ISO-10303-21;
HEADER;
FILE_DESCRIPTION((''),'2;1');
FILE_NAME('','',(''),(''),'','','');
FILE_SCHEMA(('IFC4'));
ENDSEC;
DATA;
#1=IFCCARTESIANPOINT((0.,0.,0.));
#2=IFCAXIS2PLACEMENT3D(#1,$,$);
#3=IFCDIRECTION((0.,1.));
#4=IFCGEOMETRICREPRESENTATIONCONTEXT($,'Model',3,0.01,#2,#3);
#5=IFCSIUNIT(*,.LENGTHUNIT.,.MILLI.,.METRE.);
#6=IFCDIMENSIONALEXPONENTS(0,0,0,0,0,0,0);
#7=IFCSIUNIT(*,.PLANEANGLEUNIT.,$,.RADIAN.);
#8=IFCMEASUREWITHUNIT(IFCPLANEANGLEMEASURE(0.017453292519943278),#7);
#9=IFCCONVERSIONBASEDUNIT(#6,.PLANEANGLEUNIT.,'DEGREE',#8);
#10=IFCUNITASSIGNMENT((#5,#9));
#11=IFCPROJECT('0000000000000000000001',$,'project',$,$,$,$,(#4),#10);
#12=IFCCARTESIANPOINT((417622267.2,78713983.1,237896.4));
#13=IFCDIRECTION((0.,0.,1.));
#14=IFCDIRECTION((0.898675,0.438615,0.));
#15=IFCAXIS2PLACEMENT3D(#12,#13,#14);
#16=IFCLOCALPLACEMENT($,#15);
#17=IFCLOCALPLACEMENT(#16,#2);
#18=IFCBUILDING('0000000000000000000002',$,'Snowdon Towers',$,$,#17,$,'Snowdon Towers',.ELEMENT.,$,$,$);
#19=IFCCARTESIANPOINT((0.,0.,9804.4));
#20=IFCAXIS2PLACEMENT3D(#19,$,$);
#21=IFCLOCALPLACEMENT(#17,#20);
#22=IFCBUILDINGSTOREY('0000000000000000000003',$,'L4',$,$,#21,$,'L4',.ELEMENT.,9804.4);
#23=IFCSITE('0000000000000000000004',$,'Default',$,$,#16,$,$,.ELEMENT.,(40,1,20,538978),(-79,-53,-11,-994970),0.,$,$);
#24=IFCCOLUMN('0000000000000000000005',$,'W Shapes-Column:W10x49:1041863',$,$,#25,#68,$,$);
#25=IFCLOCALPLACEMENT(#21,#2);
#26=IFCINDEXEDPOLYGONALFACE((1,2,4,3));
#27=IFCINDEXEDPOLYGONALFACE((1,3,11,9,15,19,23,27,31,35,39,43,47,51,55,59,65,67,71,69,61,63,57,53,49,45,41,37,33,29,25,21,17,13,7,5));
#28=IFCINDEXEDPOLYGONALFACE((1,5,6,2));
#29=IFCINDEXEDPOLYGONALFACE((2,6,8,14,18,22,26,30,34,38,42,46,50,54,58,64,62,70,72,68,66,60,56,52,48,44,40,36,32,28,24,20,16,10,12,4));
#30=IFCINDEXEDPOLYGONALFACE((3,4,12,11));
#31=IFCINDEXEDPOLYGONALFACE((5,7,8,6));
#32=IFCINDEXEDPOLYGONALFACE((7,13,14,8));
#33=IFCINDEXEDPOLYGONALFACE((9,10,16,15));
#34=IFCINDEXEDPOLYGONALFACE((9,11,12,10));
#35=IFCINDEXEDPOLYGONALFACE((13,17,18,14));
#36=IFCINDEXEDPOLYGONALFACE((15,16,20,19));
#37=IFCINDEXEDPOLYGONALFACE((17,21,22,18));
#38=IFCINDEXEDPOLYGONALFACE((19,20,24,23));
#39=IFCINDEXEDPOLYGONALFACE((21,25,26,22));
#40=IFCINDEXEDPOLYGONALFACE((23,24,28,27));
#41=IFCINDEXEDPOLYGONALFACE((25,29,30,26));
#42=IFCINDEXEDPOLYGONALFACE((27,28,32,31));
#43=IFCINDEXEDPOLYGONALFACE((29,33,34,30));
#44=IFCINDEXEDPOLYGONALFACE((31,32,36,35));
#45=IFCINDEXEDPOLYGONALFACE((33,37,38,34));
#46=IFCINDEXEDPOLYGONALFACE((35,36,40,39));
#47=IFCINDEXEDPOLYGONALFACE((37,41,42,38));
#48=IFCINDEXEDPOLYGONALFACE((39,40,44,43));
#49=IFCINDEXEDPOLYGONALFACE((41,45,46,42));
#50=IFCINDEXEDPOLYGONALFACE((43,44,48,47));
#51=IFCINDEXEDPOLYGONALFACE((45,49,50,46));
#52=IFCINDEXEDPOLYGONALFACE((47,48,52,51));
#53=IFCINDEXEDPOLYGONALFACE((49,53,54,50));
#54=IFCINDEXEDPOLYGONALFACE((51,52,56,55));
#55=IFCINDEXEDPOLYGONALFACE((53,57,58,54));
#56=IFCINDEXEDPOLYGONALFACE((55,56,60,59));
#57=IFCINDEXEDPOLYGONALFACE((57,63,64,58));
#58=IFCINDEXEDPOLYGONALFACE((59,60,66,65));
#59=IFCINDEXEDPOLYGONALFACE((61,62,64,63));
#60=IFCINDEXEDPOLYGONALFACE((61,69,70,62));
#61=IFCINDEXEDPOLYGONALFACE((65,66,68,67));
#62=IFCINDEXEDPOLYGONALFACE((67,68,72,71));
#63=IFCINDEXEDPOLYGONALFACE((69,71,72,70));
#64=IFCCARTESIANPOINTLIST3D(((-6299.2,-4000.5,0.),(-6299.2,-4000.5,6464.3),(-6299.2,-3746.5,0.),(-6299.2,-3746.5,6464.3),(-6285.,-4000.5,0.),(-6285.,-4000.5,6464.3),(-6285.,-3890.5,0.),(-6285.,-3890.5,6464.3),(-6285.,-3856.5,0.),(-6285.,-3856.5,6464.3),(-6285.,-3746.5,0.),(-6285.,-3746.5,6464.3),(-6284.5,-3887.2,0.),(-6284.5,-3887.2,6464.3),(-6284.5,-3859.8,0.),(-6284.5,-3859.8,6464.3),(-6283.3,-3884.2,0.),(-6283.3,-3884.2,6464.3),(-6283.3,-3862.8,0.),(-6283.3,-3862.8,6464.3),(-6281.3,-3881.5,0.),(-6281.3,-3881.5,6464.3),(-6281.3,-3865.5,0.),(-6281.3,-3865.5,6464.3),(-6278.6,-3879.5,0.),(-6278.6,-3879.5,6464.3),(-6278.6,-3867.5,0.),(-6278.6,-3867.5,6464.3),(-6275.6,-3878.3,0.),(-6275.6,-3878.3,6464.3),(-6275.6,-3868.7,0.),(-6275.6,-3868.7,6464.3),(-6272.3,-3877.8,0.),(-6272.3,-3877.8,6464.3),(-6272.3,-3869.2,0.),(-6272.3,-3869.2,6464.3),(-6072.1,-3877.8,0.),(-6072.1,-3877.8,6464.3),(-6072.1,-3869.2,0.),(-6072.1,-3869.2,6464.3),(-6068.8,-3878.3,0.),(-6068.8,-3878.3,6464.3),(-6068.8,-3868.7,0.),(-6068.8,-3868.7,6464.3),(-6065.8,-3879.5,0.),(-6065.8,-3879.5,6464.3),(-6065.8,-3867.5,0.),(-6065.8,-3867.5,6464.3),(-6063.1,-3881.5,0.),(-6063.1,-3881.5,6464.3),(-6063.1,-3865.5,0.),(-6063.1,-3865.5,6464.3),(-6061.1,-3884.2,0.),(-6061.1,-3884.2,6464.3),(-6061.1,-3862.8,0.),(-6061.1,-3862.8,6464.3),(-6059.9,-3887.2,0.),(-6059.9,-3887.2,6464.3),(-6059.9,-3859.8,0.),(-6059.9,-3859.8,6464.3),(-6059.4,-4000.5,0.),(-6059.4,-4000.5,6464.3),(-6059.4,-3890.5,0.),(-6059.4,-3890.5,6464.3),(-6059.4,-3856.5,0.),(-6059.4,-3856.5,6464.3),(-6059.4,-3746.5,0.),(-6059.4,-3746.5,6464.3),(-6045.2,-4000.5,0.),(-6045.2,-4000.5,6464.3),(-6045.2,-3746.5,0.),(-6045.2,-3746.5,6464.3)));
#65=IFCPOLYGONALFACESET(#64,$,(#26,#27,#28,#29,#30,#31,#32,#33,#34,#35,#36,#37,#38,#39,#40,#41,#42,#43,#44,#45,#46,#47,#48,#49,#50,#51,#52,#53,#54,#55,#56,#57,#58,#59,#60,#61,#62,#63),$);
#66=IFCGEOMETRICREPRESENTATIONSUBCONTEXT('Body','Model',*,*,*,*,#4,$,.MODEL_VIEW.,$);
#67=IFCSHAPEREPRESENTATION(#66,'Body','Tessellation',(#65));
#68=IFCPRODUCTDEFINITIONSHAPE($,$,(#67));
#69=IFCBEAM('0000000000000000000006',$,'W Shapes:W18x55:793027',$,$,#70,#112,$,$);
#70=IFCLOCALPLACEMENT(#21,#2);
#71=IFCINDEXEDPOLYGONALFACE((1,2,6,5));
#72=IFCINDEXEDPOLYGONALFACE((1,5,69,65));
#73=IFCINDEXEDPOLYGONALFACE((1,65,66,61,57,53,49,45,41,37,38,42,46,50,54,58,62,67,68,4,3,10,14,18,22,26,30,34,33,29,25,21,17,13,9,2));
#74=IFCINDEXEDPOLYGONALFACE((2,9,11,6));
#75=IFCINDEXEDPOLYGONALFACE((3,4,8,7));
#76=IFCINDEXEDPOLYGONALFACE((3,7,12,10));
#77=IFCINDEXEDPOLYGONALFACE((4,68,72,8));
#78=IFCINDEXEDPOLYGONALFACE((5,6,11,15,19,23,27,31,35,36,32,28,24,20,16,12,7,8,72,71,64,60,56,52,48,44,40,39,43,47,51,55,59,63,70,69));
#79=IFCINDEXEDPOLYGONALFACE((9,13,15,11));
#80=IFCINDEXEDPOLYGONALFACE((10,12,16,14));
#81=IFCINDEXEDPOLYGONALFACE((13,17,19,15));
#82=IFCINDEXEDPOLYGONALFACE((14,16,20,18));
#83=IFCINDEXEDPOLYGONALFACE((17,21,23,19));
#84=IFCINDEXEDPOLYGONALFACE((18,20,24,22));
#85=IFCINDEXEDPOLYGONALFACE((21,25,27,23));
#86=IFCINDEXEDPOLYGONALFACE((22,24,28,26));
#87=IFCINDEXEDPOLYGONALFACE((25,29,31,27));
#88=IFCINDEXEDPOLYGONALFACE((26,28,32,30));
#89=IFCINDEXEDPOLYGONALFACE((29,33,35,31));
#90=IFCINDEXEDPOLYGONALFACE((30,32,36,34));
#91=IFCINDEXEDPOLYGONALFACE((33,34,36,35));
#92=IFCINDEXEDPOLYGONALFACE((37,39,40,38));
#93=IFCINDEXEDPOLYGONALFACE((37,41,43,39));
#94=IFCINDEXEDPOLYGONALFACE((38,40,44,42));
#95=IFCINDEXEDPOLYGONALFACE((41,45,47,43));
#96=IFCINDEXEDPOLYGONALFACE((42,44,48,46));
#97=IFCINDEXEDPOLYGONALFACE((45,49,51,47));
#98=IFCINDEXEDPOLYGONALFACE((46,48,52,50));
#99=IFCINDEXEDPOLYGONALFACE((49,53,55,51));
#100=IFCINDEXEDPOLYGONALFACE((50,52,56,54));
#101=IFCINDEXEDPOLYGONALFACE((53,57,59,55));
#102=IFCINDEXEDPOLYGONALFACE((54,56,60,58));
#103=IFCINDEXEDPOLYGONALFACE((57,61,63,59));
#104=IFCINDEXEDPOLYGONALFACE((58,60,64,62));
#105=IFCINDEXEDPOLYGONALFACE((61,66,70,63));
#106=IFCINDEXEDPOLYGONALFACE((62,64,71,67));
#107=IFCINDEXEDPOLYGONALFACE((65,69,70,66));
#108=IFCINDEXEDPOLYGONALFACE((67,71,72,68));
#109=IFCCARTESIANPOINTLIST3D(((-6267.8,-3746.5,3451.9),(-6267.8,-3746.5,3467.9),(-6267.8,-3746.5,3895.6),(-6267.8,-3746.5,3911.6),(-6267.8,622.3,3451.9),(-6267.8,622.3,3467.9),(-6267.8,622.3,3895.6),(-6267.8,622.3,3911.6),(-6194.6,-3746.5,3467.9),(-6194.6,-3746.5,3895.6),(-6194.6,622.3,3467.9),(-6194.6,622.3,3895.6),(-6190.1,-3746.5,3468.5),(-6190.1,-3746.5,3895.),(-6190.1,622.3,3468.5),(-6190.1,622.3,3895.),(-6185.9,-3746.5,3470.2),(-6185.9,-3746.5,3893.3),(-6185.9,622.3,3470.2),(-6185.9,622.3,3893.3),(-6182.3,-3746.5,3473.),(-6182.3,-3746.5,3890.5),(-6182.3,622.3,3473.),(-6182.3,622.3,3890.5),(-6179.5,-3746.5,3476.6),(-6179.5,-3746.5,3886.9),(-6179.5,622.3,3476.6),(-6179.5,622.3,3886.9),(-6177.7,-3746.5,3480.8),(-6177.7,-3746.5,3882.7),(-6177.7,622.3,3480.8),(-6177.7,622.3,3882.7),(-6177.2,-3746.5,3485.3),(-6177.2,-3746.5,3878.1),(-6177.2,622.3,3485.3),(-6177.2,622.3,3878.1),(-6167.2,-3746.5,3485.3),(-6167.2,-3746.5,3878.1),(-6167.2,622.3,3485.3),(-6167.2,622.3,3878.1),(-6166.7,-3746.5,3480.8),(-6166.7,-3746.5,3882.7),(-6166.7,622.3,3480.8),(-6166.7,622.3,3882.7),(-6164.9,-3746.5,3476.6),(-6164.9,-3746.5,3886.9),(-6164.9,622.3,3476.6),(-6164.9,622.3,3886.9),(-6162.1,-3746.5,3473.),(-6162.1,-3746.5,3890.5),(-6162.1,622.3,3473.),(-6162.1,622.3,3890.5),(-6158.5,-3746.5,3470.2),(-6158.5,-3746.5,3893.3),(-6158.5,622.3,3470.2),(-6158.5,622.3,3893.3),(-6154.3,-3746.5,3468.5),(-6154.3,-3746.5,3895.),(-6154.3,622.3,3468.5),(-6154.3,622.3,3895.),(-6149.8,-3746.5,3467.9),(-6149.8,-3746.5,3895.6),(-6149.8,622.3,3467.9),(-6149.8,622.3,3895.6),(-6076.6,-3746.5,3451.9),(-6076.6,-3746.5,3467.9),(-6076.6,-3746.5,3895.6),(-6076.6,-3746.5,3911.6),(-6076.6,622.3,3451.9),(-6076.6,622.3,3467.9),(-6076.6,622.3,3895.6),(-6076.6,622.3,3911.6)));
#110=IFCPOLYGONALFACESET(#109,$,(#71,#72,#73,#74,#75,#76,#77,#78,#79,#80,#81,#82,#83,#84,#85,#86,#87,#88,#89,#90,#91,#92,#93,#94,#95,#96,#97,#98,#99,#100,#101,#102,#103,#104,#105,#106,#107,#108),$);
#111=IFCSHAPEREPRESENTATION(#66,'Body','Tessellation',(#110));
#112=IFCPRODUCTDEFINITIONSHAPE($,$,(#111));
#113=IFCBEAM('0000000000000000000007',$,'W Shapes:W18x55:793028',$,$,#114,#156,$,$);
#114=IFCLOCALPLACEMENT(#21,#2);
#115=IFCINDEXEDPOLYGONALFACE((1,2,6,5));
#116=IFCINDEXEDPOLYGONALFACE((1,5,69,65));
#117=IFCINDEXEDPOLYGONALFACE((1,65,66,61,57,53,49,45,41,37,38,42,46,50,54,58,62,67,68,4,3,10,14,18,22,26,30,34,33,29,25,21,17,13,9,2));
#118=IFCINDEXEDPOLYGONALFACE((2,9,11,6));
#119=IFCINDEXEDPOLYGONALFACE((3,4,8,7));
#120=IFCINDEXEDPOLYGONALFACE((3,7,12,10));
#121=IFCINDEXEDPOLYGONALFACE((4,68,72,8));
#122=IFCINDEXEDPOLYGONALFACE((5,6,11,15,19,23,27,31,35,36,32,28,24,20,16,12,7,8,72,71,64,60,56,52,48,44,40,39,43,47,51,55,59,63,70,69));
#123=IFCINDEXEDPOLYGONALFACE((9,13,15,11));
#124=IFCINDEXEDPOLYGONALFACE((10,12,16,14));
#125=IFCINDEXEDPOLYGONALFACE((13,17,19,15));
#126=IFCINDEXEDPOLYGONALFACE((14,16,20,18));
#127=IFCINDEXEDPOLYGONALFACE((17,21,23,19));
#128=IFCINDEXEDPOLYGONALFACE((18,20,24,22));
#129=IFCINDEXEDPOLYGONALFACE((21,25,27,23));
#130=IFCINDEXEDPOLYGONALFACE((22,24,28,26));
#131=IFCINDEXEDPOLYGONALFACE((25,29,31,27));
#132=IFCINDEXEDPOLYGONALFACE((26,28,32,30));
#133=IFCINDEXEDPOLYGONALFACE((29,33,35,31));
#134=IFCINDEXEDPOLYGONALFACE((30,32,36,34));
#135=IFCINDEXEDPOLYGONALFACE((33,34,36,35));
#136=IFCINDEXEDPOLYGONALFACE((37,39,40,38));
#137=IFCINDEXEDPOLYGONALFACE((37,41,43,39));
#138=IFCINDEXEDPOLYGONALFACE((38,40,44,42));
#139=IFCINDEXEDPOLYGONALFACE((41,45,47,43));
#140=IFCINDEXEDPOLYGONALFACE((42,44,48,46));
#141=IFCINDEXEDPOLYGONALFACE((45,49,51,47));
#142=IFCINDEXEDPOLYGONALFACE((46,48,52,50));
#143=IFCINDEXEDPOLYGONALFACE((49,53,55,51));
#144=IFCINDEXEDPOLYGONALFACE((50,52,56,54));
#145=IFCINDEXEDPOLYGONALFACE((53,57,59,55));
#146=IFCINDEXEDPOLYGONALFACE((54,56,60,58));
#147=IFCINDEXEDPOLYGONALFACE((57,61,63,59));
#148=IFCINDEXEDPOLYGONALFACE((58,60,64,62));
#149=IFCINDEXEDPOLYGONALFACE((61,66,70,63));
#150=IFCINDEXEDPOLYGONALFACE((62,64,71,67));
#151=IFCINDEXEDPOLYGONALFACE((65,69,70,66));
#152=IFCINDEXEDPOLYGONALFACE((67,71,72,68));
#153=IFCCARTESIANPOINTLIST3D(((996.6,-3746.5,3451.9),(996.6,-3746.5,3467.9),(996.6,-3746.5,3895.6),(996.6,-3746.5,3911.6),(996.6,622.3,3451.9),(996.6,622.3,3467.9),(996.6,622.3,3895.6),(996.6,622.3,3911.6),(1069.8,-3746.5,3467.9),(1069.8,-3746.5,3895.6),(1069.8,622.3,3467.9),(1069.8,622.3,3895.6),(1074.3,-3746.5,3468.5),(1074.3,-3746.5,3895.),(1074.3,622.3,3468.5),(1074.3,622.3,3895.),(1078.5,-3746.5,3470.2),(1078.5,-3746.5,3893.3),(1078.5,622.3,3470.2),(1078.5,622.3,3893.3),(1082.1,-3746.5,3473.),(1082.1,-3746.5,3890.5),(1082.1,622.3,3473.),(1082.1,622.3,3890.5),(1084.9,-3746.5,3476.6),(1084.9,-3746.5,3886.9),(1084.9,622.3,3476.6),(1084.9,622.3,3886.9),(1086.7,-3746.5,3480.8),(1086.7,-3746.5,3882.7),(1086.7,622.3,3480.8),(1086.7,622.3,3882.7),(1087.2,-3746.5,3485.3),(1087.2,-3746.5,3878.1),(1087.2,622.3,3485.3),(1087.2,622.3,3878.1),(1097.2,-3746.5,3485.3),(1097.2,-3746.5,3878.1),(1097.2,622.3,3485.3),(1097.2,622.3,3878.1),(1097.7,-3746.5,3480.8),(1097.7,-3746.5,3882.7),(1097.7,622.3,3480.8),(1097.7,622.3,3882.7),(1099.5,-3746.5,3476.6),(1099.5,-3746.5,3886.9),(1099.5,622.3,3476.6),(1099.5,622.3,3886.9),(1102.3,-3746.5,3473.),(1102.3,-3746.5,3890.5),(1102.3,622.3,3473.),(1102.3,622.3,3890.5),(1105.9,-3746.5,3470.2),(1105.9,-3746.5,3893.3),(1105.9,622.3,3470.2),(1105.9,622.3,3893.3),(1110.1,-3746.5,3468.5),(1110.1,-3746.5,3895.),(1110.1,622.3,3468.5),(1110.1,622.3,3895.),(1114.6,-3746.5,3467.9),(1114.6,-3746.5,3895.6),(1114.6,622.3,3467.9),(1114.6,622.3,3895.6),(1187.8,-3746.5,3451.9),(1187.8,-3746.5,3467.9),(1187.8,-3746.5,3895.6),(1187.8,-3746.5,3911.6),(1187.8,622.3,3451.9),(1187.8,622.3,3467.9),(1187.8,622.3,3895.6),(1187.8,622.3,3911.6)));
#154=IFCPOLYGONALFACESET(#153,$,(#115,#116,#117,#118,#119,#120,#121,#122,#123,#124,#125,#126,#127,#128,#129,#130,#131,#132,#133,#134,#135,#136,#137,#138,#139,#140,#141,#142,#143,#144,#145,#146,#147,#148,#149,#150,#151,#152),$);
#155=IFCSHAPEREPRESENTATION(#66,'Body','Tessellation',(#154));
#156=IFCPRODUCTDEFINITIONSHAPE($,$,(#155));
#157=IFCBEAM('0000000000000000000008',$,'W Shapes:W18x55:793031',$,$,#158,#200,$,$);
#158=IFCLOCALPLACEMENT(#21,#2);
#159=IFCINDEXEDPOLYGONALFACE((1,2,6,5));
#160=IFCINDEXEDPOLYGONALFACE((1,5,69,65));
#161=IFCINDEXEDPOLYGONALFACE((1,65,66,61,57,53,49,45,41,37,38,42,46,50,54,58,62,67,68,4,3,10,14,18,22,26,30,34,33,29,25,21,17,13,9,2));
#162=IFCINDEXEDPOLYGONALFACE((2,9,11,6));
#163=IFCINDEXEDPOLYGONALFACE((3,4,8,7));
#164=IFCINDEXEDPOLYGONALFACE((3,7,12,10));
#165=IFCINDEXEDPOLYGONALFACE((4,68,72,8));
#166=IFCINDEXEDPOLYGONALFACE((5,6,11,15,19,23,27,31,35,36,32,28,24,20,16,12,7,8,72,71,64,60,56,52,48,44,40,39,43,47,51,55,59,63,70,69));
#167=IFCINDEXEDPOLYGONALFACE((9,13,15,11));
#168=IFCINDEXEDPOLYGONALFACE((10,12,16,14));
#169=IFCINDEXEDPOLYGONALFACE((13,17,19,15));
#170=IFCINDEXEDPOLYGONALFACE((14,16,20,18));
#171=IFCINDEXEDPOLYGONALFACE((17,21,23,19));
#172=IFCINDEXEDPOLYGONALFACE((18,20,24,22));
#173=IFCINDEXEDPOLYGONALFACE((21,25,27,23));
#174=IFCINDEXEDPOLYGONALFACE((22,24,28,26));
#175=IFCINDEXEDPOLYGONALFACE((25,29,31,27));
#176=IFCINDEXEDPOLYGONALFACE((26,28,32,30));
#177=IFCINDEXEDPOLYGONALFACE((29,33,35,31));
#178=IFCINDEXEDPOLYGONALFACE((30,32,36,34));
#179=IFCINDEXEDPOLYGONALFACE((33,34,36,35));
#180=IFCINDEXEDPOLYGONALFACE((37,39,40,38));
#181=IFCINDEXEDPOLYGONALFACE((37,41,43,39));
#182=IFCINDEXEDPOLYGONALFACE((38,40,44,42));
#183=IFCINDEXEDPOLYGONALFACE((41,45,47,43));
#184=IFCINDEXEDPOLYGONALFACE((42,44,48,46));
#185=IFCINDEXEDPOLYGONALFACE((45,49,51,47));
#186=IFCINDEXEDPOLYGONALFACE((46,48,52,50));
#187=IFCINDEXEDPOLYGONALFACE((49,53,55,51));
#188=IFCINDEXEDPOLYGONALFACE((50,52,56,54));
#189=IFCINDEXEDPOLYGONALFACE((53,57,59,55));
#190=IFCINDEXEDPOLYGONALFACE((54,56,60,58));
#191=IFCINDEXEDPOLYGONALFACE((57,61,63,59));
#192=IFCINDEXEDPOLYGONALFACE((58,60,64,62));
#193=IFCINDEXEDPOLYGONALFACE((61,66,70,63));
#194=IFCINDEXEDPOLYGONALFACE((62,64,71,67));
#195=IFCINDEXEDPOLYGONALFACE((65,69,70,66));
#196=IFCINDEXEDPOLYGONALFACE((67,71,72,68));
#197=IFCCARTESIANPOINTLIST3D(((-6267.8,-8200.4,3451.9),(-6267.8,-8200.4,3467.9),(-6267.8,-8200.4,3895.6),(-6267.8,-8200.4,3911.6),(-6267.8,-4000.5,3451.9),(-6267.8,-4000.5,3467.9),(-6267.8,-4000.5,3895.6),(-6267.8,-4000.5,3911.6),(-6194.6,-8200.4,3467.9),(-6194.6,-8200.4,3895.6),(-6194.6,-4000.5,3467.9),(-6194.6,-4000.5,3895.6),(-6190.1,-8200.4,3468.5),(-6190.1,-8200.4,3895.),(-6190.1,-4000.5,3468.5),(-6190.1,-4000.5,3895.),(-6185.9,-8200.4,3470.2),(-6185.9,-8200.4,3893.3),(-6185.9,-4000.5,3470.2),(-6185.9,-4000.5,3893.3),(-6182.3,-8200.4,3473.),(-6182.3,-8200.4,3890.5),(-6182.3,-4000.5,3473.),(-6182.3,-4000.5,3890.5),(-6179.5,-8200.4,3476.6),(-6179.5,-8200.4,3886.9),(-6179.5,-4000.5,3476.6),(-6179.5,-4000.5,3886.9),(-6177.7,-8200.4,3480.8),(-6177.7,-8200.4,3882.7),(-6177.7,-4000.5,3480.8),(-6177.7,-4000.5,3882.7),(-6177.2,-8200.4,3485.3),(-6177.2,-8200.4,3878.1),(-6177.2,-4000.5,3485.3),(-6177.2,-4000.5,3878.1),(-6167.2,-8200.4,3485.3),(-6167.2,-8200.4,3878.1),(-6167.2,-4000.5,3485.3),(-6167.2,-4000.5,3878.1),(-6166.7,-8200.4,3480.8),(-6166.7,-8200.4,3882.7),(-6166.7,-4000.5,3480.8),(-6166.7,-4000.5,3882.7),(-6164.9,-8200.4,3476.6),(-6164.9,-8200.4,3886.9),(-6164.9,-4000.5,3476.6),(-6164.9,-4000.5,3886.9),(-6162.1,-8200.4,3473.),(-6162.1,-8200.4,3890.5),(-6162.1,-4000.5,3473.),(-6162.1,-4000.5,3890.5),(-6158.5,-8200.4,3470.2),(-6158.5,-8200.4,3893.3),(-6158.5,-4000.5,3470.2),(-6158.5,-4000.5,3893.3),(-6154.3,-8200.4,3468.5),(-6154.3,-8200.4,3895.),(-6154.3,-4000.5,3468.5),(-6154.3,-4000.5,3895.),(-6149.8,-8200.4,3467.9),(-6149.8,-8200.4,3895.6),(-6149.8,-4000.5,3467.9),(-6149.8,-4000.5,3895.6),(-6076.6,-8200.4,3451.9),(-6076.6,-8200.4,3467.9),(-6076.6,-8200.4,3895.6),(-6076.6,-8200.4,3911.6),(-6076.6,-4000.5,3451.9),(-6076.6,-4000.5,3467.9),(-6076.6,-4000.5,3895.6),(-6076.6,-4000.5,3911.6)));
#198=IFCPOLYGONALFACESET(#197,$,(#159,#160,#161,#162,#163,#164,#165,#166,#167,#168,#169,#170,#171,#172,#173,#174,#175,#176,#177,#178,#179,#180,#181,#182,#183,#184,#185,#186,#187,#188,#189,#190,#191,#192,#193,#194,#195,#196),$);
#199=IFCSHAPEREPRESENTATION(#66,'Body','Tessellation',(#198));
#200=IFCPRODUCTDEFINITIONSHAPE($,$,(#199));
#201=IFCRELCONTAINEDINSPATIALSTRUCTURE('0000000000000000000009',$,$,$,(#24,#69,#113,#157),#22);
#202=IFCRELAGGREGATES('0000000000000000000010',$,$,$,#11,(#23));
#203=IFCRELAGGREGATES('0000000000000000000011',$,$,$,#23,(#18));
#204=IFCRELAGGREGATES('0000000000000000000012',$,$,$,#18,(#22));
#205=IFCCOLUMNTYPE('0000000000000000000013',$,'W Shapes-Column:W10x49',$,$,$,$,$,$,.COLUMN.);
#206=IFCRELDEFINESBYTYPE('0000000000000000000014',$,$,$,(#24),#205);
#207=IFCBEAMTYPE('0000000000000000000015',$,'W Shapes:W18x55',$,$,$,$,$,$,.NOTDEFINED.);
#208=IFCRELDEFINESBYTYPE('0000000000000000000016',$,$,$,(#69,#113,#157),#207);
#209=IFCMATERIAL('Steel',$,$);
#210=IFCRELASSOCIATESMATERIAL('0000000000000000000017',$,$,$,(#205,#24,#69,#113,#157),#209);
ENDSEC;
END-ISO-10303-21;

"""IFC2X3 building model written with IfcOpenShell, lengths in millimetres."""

from ifc_helpers import new_model, entity, si_unit, converted_unit, direction, frame, frame_2d, origin, place, context, subcontext, project, spatial, i_section, extrude, source, transform, mapped, material, type_object, type_shapes, element, save


model = new_model("IFC2X3")

# Units and contexts
model_context = context("Model", 3, precision=0.01, world=origin(), true_north=direction((0.0, 1.0)))
body_context = subcontext(model_context, "Body", "Model", "MODEL_VIEW")
ifc_project = project(units=[si_unit("LENGTHUNIT", "METRE", prefix="MILLI"), converted_unit("PLANEANGLEUNIT", "DEGREE", entity("IfcPlaneAngleMeasure", 0.017453292519943278), si_unit("PLANEANGLEUNIT", "RADIAN"), dimensions=[0, 0, 0, 0, 0, 0, 0])], contexts=[model_context])

# Site, building, storey
site_placement = place(None, frame((417622267.2, 78713983.1, 237896.4), z_axis=(0.0, 0.0, 1.0), x_axis=(0.898675, 0.438615, 0.0)))
site = spatial("IfcSite", under=ifc_project, at=site_placement, Name="Default", CompositionType="ELEMENT", RefLatitude=(40, 1, 20, 538978), RefLongitude=(-79, -53, -11, -994970), RefElevation=0.0)
building_placement = place(site_placement, origin())
building = spatial("IfcBuilding", under=site, at=building_placement, Name="Snowdon Towers", LongName="Snowdon Towers", CompositionType="ELEMENT")
storey_placement = place(building_placement, frame((0.0, 0.0, 9804.4)))
storey = spatial("IfcBuildingStorey", under=building, at=storey_placement, Name="L4", LongName="L4", CompositionType="ELEMENT", Elevation=9804.4)

# Column
ifc_material_1 = material(Name="Steel")
column_type_1 = type_object("IfcColumnType", Name="W Shapes-Column:W10x49", PredefinedType="COLUMN", material=ifc_material_1)
shared_shape_1 = source(origin(), body_context, "Body", "SweptSolid", [
    extrude(i_section(OverallWidth=254.0, OverallDepth=254.0, WebThickness=8.6, FlangeThickness=14.2, FilletRadius=12.7, at=frame_2d((0.0, 0.0), x_axis=(1.0, 0.0))), frame((0.0, 0.0, 9804.4), z_axis=(0.0, 0.0, 1.0), x_axis=(-1.0, 0.0, 0.0)), (0.0, 0.0, 1.0), 6464.3),
])
type_shapes(column_type_1, [shared_shape_1])
column_1_placement = place(storey_placement, frame((-6172.2, -3873.5, -9804.4), z_axis=(0.0, 0.0, 1.0), x_axis=(0.0, 1.0, 0.0)))
element("IfcColumn", 1, at=column_1_placement, inside=storey, type_object=column_type_1, material=ifc_material_1, Name="W Shapes-Column:W10x49:1041863", context=body_context, shape_type="MappedRepresentation", body=[
    mapped(shared_shape_1, transform((0.0, 0.0, 0.0), scale=1.0)),
])

# Beams
beam_type_1 = type_object("IfcBeamType", Name="W Shapes:W18x55", PredefinedType="NOTDEFINED")
beam_1_placement = place(storey_placement, frame((-6172.2, 762.0, 3911.6), z_axis=(0.0, 0.0, 1.0), x_axis=(0.0, -1.0, 0.0)))
element("IfcBeam", 2, at=beam_1_placement, inside=storey, type_object=beam_type_1, material=ifc_material_1, Name="W Shapes:W18x55:793027", context=body_context, shape_type="SweptSolid", body=[
    extrude(i_section(OverallWidth=191.3, OverallDepth=459.7, WebThickness=9.9, FlangeThickness=16.0, FilletRadius=17.5, at=frame_2d((0.0, 0.0), x_axis=(0.0, 1.0))), frame((139.7, 0.0, -229.9), z_axis=(1.0, 0.0, 0.0), x_axis=(0.0, 0.0, -1.0)), (0.0, 0.0, 1.0), 4368.8),
])
beam_2_placement = place(storey_placement, frame((1092.2, 762.0, 3911.6), z_axis=(0.0, 0.0, 1.0), x_axis=(0.0, -1.0, 0.0)))
element("IfcBeam", 3, at=beam_2_placement, inside=storey, type_object=beam_type_1, material=ifc_material_1, Name="W Shapes:W18x55:793028", context=body_context, shape_type="SweptSolid", body=[
    extrude(i_section(OverallWidth=191.3, OverallDepth=459.7, WebThickness=9.9, FlangeThickness=16.0, FilletRadius=17.5, at=frame_2d((0.0, 0.0), x_axis=(0.0, 1.0))), frame((139.7, 0.0, -229.9), z_axis=(1.0, 0.0, 0.0), x_axis=(0.0, 0.0, -1.0)), (0.0, 0.0, 1.0), 4368.8),
])
beam_3_placement = place(storey_placement, frame((-6172.2, -3873.5, 3911.6), z_axis=(0.0, 0.0, 1.0), x_axis=(0.0, -1.0, 0.0)))
element("IfcBeam", 4, at=beam_3_placement, inside=storey, type_object=beam_type_1, material=ifc_material_1, Name="W Shapes:W18x55:793031", context=body_context, shape_type="SweptSolid", body=[
    extrude(i_section(OverallWidth=191.3, OverallDepth=459.7, WebThickness=9.9, FlangeThickness=16.0, FilletRadius=17.5, at=frame_2d((0.0, 0.0), x_axis=(0.0, 1.0))), frame((127.0, 0.0, -229.9), z_axis=(1.0, 0.0, 0.0), x_axis=(0.0, 0.0, -1.0)), (0.0, 0.0, 1.0), 4199.9),
])

save(model, "model.ifc")
